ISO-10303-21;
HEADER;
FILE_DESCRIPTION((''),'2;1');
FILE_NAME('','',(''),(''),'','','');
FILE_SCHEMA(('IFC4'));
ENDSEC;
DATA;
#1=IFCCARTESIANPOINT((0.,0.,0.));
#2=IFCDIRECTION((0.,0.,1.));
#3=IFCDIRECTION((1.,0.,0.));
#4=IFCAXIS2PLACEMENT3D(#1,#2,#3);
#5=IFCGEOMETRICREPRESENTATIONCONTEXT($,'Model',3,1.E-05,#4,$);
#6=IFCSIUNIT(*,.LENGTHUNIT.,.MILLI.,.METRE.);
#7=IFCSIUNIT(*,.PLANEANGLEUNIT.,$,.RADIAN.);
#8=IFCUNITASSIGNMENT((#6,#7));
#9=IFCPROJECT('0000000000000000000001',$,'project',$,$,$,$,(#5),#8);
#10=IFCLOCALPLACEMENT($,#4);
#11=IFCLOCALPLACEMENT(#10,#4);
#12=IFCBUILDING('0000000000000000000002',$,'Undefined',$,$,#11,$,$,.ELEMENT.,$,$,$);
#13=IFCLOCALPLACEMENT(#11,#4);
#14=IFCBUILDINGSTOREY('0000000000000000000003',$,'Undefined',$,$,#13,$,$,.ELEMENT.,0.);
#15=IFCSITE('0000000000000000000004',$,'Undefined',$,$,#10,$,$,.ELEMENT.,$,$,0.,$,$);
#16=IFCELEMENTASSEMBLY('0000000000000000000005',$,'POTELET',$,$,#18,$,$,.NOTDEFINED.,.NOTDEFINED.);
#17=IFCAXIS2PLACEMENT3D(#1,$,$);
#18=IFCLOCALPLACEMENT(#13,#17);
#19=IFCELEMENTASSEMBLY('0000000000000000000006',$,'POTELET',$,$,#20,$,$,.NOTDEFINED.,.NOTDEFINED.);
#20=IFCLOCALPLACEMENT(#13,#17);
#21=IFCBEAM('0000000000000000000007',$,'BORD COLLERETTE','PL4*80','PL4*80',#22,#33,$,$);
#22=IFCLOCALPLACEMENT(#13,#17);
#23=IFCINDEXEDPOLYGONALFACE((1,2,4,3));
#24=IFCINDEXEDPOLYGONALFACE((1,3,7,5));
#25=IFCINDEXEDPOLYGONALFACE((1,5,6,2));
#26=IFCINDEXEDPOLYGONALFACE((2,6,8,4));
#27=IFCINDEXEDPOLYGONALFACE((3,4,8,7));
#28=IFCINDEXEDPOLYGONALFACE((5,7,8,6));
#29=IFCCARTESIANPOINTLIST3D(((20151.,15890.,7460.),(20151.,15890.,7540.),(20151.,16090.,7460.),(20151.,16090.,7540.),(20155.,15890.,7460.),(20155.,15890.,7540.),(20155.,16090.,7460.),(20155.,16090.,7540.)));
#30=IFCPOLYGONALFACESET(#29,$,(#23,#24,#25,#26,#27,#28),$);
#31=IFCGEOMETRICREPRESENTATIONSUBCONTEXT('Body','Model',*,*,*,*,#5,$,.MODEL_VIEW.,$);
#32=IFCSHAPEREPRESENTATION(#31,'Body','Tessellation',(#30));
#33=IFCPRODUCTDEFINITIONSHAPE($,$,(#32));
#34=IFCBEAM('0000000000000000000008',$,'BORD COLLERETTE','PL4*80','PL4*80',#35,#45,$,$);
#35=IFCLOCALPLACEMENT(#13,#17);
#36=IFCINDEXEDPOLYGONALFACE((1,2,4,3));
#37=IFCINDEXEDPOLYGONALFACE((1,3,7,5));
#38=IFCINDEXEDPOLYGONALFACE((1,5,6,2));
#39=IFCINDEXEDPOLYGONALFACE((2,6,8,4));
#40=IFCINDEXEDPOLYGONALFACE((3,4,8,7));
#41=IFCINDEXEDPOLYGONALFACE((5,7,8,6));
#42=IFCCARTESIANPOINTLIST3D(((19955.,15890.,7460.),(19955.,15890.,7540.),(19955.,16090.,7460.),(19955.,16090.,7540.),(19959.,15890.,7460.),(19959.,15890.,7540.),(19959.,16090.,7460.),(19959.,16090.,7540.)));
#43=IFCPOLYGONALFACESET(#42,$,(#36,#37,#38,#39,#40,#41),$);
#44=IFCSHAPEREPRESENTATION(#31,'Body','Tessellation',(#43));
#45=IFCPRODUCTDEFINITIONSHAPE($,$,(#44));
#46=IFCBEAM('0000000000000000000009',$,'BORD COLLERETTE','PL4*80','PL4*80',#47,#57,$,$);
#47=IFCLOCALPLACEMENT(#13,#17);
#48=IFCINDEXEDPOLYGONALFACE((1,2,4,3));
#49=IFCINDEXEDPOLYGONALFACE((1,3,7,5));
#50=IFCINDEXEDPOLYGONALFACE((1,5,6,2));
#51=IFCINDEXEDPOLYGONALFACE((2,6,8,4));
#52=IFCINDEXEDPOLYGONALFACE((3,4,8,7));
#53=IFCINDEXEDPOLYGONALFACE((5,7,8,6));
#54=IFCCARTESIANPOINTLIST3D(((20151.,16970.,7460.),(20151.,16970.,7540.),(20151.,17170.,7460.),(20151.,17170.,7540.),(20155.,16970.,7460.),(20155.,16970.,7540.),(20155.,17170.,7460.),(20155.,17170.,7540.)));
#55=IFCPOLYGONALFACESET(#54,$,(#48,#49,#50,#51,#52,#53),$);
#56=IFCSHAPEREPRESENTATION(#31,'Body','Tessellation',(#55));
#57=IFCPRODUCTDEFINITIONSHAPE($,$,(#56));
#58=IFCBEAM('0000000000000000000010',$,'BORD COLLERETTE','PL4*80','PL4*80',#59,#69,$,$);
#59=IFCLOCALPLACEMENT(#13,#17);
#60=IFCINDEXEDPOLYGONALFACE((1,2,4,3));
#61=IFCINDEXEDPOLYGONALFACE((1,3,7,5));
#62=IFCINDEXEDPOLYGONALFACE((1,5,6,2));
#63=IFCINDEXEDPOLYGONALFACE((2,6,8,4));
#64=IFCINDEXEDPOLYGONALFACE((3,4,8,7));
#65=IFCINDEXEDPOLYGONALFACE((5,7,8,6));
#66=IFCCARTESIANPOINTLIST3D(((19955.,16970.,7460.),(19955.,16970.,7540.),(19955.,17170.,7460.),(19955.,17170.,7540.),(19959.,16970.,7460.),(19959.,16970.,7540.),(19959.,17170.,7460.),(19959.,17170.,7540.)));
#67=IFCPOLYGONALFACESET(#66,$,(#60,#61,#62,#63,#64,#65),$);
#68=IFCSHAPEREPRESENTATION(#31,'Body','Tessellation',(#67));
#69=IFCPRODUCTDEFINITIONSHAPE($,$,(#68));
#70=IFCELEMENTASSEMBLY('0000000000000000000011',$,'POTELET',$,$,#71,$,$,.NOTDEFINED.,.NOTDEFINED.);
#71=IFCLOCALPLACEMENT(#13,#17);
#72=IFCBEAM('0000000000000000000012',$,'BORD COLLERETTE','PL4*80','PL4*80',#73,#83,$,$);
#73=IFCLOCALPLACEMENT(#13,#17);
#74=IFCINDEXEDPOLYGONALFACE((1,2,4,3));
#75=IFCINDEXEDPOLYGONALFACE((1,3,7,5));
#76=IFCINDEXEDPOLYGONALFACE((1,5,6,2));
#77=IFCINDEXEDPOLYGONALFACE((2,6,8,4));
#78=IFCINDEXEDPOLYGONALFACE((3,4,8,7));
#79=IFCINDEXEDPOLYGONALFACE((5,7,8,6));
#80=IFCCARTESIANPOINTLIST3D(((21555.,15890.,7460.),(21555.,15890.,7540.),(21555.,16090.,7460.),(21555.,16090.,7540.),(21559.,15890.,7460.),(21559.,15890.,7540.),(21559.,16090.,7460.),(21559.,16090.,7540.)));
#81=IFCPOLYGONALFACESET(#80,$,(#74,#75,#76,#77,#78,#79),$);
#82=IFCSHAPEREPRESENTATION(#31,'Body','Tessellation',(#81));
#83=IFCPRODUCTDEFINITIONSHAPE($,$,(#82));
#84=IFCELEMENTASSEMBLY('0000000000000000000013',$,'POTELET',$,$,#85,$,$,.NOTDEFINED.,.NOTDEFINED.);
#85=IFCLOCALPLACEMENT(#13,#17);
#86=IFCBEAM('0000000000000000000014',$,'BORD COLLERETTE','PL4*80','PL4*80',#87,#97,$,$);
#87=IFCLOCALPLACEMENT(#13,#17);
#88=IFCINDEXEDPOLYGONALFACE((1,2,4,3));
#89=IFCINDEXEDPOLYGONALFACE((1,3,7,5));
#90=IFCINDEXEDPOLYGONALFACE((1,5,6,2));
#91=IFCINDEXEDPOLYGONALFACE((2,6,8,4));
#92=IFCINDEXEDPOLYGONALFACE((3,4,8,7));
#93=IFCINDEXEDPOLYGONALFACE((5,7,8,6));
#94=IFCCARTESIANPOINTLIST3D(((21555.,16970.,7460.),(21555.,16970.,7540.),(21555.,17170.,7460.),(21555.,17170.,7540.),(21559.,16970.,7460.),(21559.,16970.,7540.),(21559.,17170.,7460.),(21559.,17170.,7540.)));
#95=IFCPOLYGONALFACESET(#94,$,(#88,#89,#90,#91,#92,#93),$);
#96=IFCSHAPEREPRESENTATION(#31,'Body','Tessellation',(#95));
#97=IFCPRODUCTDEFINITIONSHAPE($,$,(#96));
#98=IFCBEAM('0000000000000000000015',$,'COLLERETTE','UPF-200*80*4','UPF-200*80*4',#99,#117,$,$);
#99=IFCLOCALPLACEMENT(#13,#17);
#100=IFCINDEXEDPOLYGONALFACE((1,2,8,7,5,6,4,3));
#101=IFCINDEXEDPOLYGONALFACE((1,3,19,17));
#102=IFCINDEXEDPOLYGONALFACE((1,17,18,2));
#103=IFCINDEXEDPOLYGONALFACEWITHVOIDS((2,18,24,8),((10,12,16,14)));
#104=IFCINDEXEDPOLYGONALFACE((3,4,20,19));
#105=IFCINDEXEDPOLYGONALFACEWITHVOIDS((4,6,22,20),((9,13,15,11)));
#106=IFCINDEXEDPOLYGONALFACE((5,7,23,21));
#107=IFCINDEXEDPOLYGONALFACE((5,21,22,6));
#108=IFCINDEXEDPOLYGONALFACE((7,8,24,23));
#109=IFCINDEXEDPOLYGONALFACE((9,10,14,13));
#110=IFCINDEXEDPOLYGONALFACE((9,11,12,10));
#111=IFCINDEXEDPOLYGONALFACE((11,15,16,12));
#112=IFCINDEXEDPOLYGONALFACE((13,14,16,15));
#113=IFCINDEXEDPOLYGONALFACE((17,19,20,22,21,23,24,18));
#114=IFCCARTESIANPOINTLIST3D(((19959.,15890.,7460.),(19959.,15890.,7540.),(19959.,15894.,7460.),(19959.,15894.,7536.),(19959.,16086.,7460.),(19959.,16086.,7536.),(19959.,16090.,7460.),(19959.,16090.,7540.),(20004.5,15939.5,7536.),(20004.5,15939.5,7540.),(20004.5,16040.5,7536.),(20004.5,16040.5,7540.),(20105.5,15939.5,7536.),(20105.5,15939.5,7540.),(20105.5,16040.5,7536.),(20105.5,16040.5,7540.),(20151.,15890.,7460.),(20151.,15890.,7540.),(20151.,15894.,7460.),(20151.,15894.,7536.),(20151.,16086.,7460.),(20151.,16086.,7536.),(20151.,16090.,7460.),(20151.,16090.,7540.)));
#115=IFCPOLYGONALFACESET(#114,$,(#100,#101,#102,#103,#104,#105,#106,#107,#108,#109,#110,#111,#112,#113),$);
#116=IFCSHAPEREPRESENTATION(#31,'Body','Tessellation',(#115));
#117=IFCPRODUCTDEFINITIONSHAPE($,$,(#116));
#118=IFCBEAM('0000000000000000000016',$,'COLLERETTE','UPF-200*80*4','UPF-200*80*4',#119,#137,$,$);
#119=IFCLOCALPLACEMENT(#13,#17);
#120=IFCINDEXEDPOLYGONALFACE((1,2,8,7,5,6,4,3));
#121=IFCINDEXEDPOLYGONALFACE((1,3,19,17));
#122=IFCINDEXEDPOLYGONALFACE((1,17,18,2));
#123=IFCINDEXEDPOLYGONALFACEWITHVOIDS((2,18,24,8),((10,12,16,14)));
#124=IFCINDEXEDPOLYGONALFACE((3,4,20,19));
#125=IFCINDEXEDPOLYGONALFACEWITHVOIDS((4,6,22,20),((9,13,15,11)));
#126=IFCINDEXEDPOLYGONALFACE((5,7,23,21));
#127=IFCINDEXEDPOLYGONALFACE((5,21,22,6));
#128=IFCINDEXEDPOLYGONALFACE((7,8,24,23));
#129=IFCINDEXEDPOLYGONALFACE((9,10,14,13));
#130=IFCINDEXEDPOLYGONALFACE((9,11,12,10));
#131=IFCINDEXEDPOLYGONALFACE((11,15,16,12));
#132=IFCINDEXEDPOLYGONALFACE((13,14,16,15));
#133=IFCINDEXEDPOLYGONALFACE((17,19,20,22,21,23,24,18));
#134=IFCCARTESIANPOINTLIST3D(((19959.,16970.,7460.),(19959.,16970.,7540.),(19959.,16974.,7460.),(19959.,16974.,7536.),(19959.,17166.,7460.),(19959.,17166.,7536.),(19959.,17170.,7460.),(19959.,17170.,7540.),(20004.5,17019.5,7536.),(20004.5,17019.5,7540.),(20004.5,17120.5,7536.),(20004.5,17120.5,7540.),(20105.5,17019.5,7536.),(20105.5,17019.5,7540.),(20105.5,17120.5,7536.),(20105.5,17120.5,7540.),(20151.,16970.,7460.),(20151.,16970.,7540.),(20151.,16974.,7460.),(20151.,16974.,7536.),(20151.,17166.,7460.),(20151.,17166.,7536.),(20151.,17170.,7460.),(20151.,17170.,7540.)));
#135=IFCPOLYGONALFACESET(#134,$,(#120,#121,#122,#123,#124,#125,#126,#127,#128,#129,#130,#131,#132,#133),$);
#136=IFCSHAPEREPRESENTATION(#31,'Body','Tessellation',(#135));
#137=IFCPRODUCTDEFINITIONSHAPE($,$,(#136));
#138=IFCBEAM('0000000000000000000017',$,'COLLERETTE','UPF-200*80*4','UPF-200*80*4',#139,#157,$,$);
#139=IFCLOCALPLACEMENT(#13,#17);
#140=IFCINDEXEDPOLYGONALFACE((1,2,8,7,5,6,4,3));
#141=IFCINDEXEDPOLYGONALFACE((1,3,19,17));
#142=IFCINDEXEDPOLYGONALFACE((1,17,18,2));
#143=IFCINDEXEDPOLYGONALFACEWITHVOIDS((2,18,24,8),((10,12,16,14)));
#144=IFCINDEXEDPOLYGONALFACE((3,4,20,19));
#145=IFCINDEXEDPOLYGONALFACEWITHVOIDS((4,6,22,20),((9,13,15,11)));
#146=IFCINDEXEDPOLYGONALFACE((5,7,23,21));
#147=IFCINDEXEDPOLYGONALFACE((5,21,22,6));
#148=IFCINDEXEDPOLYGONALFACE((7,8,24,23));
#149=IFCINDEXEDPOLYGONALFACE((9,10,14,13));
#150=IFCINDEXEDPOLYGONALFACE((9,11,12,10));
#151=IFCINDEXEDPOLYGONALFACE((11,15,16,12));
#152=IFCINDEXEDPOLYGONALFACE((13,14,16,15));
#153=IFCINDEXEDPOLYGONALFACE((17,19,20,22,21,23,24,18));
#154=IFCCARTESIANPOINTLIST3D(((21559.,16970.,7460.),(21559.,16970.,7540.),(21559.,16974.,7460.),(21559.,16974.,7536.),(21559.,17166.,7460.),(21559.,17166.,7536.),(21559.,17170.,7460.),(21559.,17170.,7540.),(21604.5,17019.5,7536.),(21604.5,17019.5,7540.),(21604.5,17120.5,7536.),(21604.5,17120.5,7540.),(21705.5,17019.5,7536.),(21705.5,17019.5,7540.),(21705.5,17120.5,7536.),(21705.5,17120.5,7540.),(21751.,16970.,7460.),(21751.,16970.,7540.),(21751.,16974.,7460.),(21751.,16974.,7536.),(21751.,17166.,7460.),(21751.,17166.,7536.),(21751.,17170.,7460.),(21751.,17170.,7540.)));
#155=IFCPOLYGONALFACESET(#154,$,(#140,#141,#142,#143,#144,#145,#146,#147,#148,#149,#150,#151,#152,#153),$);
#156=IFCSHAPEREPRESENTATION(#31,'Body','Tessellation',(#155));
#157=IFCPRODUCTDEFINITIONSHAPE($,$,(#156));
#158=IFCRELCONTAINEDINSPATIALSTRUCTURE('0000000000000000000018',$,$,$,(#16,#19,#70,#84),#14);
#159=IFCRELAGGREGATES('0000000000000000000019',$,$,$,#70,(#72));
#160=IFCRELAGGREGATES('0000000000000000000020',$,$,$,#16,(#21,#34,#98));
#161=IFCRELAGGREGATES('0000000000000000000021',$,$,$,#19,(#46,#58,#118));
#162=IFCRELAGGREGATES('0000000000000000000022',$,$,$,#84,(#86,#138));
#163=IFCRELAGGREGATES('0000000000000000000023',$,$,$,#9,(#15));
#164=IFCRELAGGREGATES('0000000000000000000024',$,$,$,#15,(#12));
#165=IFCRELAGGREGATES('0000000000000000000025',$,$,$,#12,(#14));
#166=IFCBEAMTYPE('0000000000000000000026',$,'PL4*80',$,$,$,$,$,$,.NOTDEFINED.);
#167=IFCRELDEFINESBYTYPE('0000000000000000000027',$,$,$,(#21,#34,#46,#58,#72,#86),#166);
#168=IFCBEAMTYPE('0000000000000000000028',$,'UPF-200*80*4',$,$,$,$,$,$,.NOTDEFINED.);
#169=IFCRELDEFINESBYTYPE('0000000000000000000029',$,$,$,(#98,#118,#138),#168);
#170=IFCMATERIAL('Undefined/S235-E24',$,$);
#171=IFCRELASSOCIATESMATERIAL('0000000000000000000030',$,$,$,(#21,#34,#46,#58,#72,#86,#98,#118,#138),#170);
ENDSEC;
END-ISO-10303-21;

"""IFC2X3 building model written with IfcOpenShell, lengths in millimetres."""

from ifc_helpers import new_model, si_unit, frame, origin_with_axes, origin_2d_with_axis, place, context, subcontext, project, spatial, polyline, rectangle, u_section, outline, extrude, boolean, material, type_object, element, aggregate, save


model = new_model("IFC2X3")

# Units and contexts
model_context = context("Model", 3, precision=1e-05, world=origin_with_axes())
body_context = subcontext(model_context, "Body", "Model", "MODEL_VIEW")
ifc_project = project(units=[si_unit("LENGTHUNIT", "METRE", prefix="MILLI"), si_unit("PLANEANGLEUNIT", "RADIAN")], contexts=[model_context])

# Site, building, storey
site_placement = place(None, origin_with_axes())
site = spatial("IfcSite", under=ifc_project, at=site_placement, Name="Undefined", CompositionType="ELEMENT", RefElevation=0.0)
building_placement = place(site_placement, origin_with_axes())
building = spatial("IfcBuilding", under=site, at=building_placement, Name="Undefined", CompositionType="ELEMENT")
storey_placement = place(building_placement, origin_with_axes())
storey = spatial("IfcBuildingStorey", under=building, at=storey_placement, Name="Undefined", CompositionType="ELEMENT", Elevation=0.0)

# Element assemblies
assembly_1_placement = place(storey_placement, origin_with_axes())
assembly_1 = element("IfcElementAssembly", 1, at=assembly_1_placement, inside=storey, Name="POTELET", AssemblyPlace="NOTDEFINED", PredefinedType="NOTDEFINED")
ifc_material_1 = material(Name="Undefined/S235-E24")
assembly_2_placement = place(storey_placement, origin_with_axes())
assembly_2 = element("IfcElementAssembly", 2, at=assembly_2_placement, inside=storey, Name="POTELET", AssemblyPlace="NOTDEFINED", PredefinedType="NOTDEFINED")

# Beams
beam_type_1 = type_object("IfcBeamType", Name="PL4*80", PredefinedType="NOTDEFINED")
beam_1_placement = place(assembly_1_placement, frame((20153.0, 16090.0, 7500.0), z_axis=(0.0, 0.0, 1.0), x_axis=(0.0, -1.0, 0.0)))
beam_1 = element("IfcBeam", 3, at=beam_1_placement, type_object=beam_type_1, material=ifc_material_1, Name="BORD COLLERETTE", Description="PL4*80", ObjectType="PL4*80", context=body_context, shape_type="SweptSolid", body=[
    extrude(rectangle(XDim=4.0, YDim=80.0, at=origin_2d_with_axis()), frame((200.0, 0.0, 0.0), z_axis=(-1.0, 0.0, 0.0), x_axis=(0.0, -1.0, 0.0)), (0.0, 0.0, 1.0), 200.0),
])
beam_2_placement = place(assembly_1_placement, frame((19957.0, 16090.0, 7500.0), z_axis=(0.0, 0.0, 1.0), x_axis=(0.0, -1.0, 0.0)))
beam_2 = element("IfcBeam", 4, at=beam_2_placement, type_object=beam_type_1, material=ifc_material_1, Name="BORD COLLERETTE", Description="PL4*80", ObjectType="PL4*80", context=body_context, shape_type="SweptSolid", body=[
    extrude(rectangle(XDim=4.0, YDim=80.0, at=origin_2d_with_axis()), frame((200.0, 0.0, 0.0), z_axis=(-1.0, 0.0, 0.0), x_axis=(0.0, -1.0, 0.0)), (0.0, 0.0, 1.0), 200.0),
])
beam_3_placement = place(assembly_2_placement, frame((20153.0, 16970.0, 7500.0), z_axis=(0.0, 0.0, 1.0), x_axis=(0.0, 1.0, 0.0)))
beam_3 = element("IfcBeam", 5, at=beam_3_placement, type_object=beam_type_1, material=ifc_material_1, Name="BORD COLLERETTE", Description="PL4*80", ObjectType="PL4*80", context=body_context, shape_type="SweptSolid", body=[
    extrude(rectangle(XDim=4.0, YDim=80.0, at=origin_2d_with_axis()), frame((200.0, 0.0, 0.0), z_axis=(-1.0, 0.0, 0.0), x_axis=(0.0, -1.0, 0.0)), (0.0, 0.0, 1.0), 200.0),
])
beam_4_placement = place(assembly_2_placement, frame((19957.0, 16970.0, 7500.0), z_axis=(0.0, 0.0, 1.0), x_axis=(0.0, 1.0, 0.0)))
beam_4 = element("IfcBeam", 6, at=beam_4_placement, type_object=beam_type_1, material=ifc_material_1, Name="BORD COLLERETTE", Description="PL4*80", ObjectType="PL4*80", context=body_context, shape_type="SweptSolid", body=[
    extrude(rectangle(XDim=4.0, YDim=80.0, at=origin_2d_with_axis()), frame((200.0, 0.0, 0.0), z_axis=(-1.0, 0.0, 0.0), x_axis=(0.0, -1.0, 0.0)), (0.0, 0.0, 1.0), 200.0),
])

# Element assemblies, beams
assembly_3_placement = place(storey_placement, origin_with_axes())
assembly_3 = element("IfcElementAssembly", 7, at=assembly_3_placement, inside=storey, Name="POTELET", AssemblyPlace="NOTDEFINED", PredefinedType="NOTDEFINED")
beam_5_placement = place(assembly_3_placement, frame((21557.0, 16090.0, 7500.0), z_axis=(0.0, 0.0, 1.0), x_axis=(0.0, -1.0, 0.0)))
beam_5 = element("IfcBeam", 8, at=beam_5_placement, type_object=beam_type_1, material=ifc_material_1, Name="BORD COLLERETTE", Description="PL4*80", ObjectType="PL4*80", context=body_context, shape_type="SweptSolid", body=[
    extrude(rectangle(XDim=4.0, YDim=80.0, at=origin_2d_with_axis()), frame((200.0, 0.0, 0.0), z_axis=(-1.0, 0.0, 0.0), x_axis=(0.0, -1.0, 0.0)), (0.0, 0.0, 1.0), 200.0),
])
aggregate(assembly_3, [beam_5])
assembly_4_placement = place(storey_placement, origin_with_axes())
assembly_4 = element("IfcElementAssembly", 9, at=assembly_4_placement, inside=storey, Name="POTELET", AssemblyPlace="NOTDEFINED", PredefinedType="NOTDEFINED")
beam_6_placement = place(assembly_4_placement, frame((21557.0, 16970.0, 7500.0), z_axis=(0.0, 0.0, 1.0), x_axis=(0.0, 1.0, 0.0)))
beam_6 = element("IfcBeam", 10, at=beam_6_placement, type_object=beam_type_1, material=ifc_material_1, Name="BORD COLLERETTE", Description="PL4*80", ObjectType="PL4*80", context=body_context, shape_type="SweptSolid", body=[
    extrude(rectangle(XDim=4.0, YDim=80.0, at=origin_2d_with_axis()), frame((200.0, 0.0, 0.0), z_axis=(-1.0, 0.0, 0.0), x_axis=(0.0, -1.0, 0.0)), (0.0, 0.0, 1.0), 200.0),
])

# Beams
beam_type_2 = type_object("IfcBeamType", Name="UPF-200*80*4", PredefinedType="NOTDEFINED")
beam_7_placement = place(assembly_1_placement, frame((20151.0, 15990.0, 7500.0), z_axis=(0.0, 1.0, 0.0), x_axis=(-1.0, 0.0, 0.0)))
beam_7 = element("IfcBeam", 11, at=beam_7_placement, type_object=beam_type_2, material=ifc_material_1, Name="COLLERETTE", Description="UPF-200*80*4", ObjectType="UPF-200*80*4", context=body_context, shape_type="CSG", body=[
    boolean("DIFFERENCE", extrude(u_section(Depth=200.0, FlangeWidth=80.0, WebThickness=4.0, FlangeThickness=4.0, at=origin_2d_with_axis()), frame((192.0, 0.0, 0.0), z_axis=(-1.0, 0.0, 0.0), x_axis=(0.0, -1.0, 0.0)), (0.0, 0.0, 1.0), 192.0), extrude(outline(polyline([(0.0, 0.0), (101.0, 0.0), (101.0, 101.0), (0.0, 101.0), (0.0, 0.0)])), frame((146.5, -42.5, 50.5), z_axis=(0.0, 1.0, 0.0), x_axis=(0.0, 0.0, -1.0)), (0.0, 0.0, 1.0), 85.0)),
])
aggregate(assembly_1, [beam_1, beam_2, beam_7])
beam_8_placement = place(assembly_2_placement, frame((19959.0, 17070.0, 7500.0), z_axis=(0.0, -1.0, 0.0), x_axis=(1.0, 0.0, 0.0)))
beam_8 = element("IfcBeam", 12, at=beam_8_placement, type_object=beam_type_2, material=ifc_material_1, Name="COLLERETTE", Description="UPF-200*80*4", ObjectType="UPF-200*80*4", context=body_context, shape_type="CSG", body=[
    boolean("DIFFERENCE", extrude(u_section(Depth=200.0, FlangeWidth=80.0, WebThickness=4.0, FlangeThickness=4.0, at=origin_2d_with_axis()), frame((192.0, 0.0, 0.0), z_axis=(-1.0, 0.0, 0.0), x_axis=(0.0, -1.0, 0.0)), (0.0, 0.0, 1.0), 192.0), extrude(outline(polyline([(0.0, 0.0), (101.0, 0.0), (101.0, 101.0), (0.0, 101.0), (0.0, 0.0)])), frame((45.5, -42.5, -50.5), z_axis=(0.0, 1.0, 0.0), x_axis=(0.0, 0.0, 1.0)), (0.0, 0.0, 1.0), 85.0)),
])
aggregate(assembly_2, [beam_3, beam_4, beam_8])
beam_9_placement = place(assembly_4_placement, frame((21559.0, 17070.0, 7500.0), z_axis=(0.0, -1.0, 0.0), x_axis=(1.0, 0.0, 0.0)))
beam_9 = element("IfcBeam", 13, at=beam_9_placement, type_object=beam_type_2, material=ifc_material_1, Name="COLLERETTE", Description="UPF-200*80*4", ObjectType="UPF-200*80*4", context=body_context, shape_type="CSG", body=[
    boolean("DIFFERENCE", extrude(u_section(Depth=200.0, FlangeWidth=80.0, WebThickness=4.0, FlangeThickness=4.0, at=origin_2d_with_axis()), frame((192.0, 0.0, 0.0), z_axis=(-1.0, 0.0, 0.0), x_axis=(0.0, -1.0, 0.0)), (0.0, 0.0, 1.0), 192.0), extrude(outline(polyline([(0.0, 0.0), (101.0, 0.0), (101.0, 101.0), (0.0, 101.0), (0.0, 0.0)])), frame((45.5, -42.5, -50.5), z_axis=(0.0, 1.0, 0.0), x_axis=(0.0, 0.0, 1.0)), (0.0, 0.0, 1.0), 85.0)),
])
aggregate(assembly_4, [beam_6, beam_9])

save(model, "model.ifc")
